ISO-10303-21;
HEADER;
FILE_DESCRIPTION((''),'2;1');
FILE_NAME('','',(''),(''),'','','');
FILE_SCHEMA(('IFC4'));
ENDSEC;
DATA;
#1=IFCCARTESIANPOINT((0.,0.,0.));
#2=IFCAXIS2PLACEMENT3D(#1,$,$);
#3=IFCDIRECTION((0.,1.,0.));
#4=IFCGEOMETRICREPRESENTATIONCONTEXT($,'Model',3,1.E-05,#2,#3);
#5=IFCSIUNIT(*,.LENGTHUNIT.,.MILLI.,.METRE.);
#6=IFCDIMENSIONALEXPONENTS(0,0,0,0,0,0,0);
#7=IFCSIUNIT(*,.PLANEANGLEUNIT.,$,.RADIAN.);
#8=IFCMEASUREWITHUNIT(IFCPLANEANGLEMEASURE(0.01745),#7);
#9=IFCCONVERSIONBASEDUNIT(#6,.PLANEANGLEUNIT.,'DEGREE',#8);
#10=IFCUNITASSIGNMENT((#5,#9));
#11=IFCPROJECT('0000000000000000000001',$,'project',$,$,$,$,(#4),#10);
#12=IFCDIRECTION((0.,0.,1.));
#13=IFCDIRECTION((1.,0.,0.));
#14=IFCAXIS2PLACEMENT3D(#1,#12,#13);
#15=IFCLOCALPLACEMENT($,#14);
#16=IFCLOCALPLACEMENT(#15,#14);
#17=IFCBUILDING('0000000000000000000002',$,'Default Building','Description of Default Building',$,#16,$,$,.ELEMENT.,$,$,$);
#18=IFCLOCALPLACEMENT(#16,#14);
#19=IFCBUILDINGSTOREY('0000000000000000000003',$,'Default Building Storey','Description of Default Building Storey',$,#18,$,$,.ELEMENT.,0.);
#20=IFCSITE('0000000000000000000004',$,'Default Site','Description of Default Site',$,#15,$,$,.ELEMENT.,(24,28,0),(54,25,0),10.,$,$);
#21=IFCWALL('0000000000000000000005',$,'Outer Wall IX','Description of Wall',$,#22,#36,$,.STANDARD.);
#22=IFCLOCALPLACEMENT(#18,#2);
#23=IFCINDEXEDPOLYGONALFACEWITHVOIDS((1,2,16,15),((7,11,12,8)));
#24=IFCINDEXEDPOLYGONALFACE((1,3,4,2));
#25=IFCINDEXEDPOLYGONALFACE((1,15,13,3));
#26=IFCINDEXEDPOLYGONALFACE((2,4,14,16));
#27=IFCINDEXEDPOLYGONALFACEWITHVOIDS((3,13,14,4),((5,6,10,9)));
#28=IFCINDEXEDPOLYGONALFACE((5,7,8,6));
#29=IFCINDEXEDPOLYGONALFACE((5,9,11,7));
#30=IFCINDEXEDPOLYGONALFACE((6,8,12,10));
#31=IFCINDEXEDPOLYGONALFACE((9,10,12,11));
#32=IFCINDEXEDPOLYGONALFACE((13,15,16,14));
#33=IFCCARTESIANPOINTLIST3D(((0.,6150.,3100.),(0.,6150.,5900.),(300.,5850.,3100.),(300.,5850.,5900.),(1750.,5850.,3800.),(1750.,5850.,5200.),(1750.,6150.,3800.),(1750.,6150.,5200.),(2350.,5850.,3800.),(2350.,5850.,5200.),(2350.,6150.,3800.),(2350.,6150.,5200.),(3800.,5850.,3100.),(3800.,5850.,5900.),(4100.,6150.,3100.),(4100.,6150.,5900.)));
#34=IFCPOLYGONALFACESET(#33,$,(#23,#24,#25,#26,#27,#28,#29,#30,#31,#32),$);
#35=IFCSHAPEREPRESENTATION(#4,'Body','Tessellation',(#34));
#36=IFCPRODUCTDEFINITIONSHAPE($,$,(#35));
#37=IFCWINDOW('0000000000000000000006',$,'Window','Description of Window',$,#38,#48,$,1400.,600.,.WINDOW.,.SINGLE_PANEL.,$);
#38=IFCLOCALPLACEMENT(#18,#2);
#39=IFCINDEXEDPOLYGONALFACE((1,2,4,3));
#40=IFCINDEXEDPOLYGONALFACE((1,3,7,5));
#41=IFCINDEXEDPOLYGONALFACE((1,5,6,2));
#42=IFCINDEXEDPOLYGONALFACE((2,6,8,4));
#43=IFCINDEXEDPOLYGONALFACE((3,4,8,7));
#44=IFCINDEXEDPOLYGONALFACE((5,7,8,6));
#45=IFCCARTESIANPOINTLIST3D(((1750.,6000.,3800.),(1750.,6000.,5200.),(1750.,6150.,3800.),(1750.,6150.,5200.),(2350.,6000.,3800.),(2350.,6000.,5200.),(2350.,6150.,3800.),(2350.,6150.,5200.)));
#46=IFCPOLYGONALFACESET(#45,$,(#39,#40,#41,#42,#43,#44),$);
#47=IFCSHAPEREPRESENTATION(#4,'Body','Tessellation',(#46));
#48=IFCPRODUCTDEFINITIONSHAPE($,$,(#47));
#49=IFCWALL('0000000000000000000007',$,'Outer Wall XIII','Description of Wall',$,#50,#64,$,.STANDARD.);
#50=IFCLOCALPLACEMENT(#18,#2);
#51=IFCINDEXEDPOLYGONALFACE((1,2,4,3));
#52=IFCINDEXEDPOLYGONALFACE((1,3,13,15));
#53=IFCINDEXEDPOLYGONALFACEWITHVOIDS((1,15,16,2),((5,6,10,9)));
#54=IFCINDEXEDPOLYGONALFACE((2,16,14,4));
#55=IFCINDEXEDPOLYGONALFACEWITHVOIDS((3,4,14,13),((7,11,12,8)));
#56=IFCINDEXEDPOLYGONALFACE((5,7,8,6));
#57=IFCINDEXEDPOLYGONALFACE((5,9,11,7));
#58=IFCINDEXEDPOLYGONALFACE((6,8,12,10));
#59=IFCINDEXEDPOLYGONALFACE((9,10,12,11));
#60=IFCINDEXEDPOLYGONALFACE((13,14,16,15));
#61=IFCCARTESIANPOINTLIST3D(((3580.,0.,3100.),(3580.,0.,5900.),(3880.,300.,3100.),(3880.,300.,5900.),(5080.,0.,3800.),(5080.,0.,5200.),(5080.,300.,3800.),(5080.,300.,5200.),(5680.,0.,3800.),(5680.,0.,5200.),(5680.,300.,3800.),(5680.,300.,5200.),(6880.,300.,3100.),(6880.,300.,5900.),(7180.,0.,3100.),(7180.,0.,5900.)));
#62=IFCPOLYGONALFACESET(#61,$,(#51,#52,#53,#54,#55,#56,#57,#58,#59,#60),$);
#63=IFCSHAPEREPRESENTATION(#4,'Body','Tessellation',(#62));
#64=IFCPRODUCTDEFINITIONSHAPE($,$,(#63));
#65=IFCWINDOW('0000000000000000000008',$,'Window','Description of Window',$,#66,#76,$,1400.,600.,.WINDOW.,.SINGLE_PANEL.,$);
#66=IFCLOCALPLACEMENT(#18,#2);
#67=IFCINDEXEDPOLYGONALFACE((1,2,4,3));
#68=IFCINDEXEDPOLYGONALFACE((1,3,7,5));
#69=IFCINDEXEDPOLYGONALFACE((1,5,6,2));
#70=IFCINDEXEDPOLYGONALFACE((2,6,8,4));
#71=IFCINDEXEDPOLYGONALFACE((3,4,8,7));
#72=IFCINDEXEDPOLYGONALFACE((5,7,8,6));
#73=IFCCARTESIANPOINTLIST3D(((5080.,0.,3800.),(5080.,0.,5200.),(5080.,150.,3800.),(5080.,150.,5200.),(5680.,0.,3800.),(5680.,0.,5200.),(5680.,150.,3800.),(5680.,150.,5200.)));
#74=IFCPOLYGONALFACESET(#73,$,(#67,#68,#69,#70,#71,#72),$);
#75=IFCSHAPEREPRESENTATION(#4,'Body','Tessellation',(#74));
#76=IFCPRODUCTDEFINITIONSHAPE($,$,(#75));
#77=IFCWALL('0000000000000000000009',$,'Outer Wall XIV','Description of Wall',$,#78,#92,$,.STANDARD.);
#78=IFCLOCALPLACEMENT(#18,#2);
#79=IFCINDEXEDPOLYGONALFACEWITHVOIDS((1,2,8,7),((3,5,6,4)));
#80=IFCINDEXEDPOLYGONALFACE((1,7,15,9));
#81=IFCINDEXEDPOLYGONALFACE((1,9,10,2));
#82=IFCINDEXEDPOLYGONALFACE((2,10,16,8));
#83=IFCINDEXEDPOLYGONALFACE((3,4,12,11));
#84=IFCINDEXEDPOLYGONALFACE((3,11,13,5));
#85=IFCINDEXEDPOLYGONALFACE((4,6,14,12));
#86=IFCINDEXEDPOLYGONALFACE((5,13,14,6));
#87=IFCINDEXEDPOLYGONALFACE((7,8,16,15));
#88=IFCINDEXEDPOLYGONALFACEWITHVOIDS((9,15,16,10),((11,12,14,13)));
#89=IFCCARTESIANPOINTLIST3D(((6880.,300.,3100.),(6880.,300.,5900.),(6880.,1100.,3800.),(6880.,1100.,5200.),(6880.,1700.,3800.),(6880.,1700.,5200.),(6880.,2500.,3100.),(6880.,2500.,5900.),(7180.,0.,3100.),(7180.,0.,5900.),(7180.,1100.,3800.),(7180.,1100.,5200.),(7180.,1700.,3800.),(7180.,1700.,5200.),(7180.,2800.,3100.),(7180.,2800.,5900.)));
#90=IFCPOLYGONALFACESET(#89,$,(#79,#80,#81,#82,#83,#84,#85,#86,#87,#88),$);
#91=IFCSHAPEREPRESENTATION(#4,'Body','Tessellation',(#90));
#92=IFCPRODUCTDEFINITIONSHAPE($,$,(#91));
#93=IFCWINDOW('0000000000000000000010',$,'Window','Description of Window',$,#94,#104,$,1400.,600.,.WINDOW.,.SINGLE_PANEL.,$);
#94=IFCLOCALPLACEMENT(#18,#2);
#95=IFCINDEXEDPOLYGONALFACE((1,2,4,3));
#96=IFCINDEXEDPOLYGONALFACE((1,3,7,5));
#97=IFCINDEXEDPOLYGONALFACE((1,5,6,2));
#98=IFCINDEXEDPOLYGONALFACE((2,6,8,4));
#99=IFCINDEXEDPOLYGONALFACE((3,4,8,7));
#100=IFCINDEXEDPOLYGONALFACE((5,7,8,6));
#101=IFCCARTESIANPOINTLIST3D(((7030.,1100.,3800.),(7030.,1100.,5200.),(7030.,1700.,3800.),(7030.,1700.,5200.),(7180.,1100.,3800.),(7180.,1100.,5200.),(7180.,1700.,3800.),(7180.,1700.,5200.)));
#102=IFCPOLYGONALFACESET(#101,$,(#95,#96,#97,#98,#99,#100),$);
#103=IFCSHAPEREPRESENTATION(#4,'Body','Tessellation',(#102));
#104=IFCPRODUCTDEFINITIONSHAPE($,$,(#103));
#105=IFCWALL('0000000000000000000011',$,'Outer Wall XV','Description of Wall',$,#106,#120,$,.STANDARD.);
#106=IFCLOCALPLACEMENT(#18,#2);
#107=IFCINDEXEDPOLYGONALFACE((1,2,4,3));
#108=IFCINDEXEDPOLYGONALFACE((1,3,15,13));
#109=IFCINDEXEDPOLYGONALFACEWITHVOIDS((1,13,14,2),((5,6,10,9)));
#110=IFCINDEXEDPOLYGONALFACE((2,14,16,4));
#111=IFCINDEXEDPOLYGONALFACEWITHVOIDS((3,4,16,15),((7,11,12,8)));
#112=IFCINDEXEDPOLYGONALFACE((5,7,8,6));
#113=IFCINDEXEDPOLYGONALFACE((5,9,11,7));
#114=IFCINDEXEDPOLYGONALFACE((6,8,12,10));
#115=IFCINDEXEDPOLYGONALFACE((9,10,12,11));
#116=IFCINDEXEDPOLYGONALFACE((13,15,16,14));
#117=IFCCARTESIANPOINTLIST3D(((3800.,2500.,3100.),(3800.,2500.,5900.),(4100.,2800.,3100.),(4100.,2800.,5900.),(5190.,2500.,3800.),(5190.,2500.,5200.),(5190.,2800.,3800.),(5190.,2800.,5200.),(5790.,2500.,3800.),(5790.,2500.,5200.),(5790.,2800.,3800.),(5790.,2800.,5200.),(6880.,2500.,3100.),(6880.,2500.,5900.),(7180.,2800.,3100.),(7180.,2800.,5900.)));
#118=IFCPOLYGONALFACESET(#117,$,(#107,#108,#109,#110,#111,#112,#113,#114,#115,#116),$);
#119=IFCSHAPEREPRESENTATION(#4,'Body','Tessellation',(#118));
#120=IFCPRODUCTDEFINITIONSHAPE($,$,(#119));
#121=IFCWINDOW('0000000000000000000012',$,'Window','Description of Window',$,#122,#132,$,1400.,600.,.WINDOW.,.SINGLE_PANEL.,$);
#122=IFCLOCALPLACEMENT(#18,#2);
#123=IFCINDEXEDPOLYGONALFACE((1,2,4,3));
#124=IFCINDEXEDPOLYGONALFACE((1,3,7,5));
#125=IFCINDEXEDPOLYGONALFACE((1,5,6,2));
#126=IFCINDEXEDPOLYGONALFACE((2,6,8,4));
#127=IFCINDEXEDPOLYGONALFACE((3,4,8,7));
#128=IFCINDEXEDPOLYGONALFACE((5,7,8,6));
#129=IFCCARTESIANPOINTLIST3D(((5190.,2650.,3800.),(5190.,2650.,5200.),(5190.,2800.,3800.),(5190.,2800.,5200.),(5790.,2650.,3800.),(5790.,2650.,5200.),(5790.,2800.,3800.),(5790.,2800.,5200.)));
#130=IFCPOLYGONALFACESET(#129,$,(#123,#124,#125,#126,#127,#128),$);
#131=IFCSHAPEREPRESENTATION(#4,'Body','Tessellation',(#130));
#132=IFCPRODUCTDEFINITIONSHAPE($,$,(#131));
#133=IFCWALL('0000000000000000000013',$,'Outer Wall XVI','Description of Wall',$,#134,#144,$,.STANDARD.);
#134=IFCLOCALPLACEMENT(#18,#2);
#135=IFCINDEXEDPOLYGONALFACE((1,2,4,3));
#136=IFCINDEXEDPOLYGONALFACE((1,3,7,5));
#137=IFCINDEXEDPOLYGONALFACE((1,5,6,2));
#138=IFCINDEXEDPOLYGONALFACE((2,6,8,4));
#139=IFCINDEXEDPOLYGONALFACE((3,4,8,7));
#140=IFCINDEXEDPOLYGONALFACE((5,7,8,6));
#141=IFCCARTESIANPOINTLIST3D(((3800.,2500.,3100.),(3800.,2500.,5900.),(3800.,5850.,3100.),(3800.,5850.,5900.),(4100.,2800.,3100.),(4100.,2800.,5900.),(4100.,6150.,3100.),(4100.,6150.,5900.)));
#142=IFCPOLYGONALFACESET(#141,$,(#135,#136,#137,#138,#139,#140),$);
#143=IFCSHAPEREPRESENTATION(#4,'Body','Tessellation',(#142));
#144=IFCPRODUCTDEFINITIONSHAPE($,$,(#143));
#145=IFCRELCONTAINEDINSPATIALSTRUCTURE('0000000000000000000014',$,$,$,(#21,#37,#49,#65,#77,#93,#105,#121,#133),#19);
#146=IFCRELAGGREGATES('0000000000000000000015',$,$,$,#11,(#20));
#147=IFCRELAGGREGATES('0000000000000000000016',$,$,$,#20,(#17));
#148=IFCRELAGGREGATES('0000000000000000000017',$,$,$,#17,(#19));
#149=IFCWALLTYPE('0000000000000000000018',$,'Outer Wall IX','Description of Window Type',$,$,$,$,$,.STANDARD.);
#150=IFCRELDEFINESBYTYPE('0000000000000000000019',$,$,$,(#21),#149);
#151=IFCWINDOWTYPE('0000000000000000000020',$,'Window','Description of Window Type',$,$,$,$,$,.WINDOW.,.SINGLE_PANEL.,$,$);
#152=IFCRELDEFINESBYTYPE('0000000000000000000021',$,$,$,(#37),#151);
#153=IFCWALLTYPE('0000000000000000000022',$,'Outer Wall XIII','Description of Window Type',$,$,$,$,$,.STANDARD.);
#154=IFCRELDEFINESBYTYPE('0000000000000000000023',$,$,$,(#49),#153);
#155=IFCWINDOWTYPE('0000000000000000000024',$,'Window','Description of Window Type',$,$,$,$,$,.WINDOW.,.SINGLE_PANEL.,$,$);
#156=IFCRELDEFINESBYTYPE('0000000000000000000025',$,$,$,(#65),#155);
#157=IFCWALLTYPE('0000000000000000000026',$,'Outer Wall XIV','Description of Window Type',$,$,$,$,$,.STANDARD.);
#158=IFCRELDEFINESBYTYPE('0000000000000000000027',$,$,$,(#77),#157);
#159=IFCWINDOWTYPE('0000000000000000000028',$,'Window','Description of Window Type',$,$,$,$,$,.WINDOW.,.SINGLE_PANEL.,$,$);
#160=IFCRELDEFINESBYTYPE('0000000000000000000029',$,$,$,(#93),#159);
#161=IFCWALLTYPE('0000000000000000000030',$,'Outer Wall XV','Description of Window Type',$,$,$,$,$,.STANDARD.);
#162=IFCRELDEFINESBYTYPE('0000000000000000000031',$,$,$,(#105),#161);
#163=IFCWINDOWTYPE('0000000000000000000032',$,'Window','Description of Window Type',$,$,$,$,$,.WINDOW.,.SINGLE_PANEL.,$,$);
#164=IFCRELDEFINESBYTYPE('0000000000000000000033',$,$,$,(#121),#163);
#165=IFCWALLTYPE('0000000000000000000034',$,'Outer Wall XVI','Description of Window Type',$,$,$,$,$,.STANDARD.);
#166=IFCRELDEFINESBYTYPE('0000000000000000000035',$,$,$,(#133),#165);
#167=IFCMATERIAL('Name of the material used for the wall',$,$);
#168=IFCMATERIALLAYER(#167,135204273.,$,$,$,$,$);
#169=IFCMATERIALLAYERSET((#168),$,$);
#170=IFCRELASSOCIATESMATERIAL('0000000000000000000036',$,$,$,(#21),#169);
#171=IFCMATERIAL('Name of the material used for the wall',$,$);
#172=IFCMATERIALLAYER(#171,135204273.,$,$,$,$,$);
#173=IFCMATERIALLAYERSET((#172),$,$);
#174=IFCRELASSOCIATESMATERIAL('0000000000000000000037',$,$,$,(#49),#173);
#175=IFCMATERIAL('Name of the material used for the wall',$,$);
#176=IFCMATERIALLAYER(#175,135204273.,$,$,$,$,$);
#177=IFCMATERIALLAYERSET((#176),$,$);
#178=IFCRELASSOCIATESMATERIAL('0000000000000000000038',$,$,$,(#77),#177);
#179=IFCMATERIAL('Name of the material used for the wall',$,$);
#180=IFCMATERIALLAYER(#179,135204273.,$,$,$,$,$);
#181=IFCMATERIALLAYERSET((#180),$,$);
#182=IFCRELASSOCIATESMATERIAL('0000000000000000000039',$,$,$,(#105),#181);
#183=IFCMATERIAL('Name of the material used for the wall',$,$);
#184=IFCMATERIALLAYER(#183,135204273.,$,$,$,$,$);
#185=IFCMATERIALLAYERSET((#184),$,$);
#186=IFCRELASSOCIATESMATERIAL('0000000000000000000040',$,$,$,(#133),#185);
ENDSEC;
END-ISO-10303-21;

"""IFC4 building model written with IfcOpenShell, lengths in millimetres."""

from ifc_helpers import new_model, entity, si_unit, converted_unit, direction, frame, origin, origin_with_axes, place, context, project, spatial, polyline, outline, extrude, material, layer, layer_set, layer_usage, type_object, element, fill, save


model = new_model("IFC4")

# Units and contexts
model_context = context("Model", 3, precision=1e-05, world=origin(), true_north=direction((0.0, 1.0, 0.0)))
ifc_project = project(units=[si_unit("LENGTHUNIT", "METRE", prefix="MILLI"), converted_unit("PLANEANGLEUNIT", "DEGREE", entity("IfcPlaneAngleMeasure", 0.01745), si_unit("PLANEANGLEUNIT", "RADIAN"), dimensions=[0, 0, 0, 0, 0, 0, 0])], contexts=[model_context])

# Site, building, storey
site_placement = place(None, origin_with_axes())
site = spatial("IfcSite", under=ifc_project, at=site_placement, Name="Default Site", Description="Description of Default Site", CompositionType="ELEMENT", RefLatitude=(24, 28, 0), RefLongitude=(54, 25, 0), RefElevation=10.0)
building_placement = place(site_placement, origin_with_axes())
building = spatial("IfcBuilding", under=site, at=building_placement, Name="Default Building", Description="Description of Default Building", CompositionType="ELEMENT")
storey_placement = place(building_placement, origin_with_axes())
storey = spatial("IfcBuildingStorey", under=building, at=storey_placement, Name="Default Building Storey", Description="Description of Default Building Storey", CompositionType="ELEMENT", Elevation=0.0)

# Walls, openings, windows
ifc_material_1 = material(Name="Name of the material used for the wall")
ifc_layer_1 = layer(ifc_material_1, 135204273.0)
ifc_layer_set_1 = layer_set([ifc_layer_1])
ifc_layer_usage_1 = layer_usage(ifc_layer_set_1, "AXIS2", "POSITIVE", -67602136.5)
wall_type_1 = type_object("IfcWallType", Name="Outer Wall IX", Description="Description of Window Type", PredefinedType="STANDARD")
wall_1_placement = place(storey_placement, frame((3950.0, 6000.0, 3100.0), z_axis=(0.0, 0.0, 1.0), x_axis=(-1.0, 0.0, 0.0)))
wall_1 = element("IfcWall", 1, at=wall_1_placement, inside=storey, type_object=wall_type_1, material=ifc_layer_usage_1, Name="Outer Wall IX", Description="Description of Wall", PredefinedType="STANDARD", context=model_context, shape_type="SweptSolid", body=[
    extrude(outline(polyline([(-150.0, -150.0), (150.0, 150.0), (3650.0, 150.0), (3950.0, -150.0), (-150.0, -150.0)])), origin_with_axes(), (0.0, 0.0, 1.0), 2800.0),
])
opening_1_placement = place(wall_1_placement, frame((1600.0, -150.0, 700.0), z_axis=(0.0, 0.0, 1.0), x_axis=(1.0, 0.0, 0.0)))
opening_1 = element("IfcOpeningElement", 2, at=opening_1_placement, cuts=wall_1, context=model_context, shape_type="SweptSolid", body=[
    extrude(outline(polyline([(0.0, 0.0), (0.0, 300.0), (600.0, 300.0), (600.0, 0.0), (0.0, 0.0)])), origin_with_axes(), (0.0, 0.0, 1.0), 1400.0),
])
window_type_1 = type_object("IfcWindowType", Name="Window", Description="Description of Window Type", PartitioningType="SINGLE_PANEL", PredefinedType="WINDOW")
window_1_placement = place(opening_1_placement, origin_with_axes())
window_1 = element("IfcWindow", 3, at=window_1_placement, inside=storey, type_object=window_type_1, Name="Window", Description="Description of Window", OverallHeight=1400.0, OverallWidth=600.0, PartitioningType="SINGLE_PANEL", PredefinedType="WINDOW", context=model_context, shape_type="SweptSolid", body=[
    extrude(outline(polyline([(0.0, 0.0), (0.0, 150.0), (600.0, 150.0), (600.0, 0.0), (0.0, 0.0)])), origin_with_axes(), (0.0, 0.0, 1.0), 1400.0),
])
fill(opening_1, window_1)
ifc_material_2 = material(Name="Name of the material used for the wall")
ifc_layer_2 = layer(ifc_material_2, 135204273.0)
ifc_layer_set_2 = layer_set([ifc_layer_2])
ifc_layer_usage_2 = layer_usage(ifc_layer_set_2, "AXIS2", "POSITIVE", -67602136.5)
wall_type_2 = type_object("IfcWallType", Name="Outer Wall XIII", Description="Description of Window Type", PredefinedType="STANDARD")
wall_2_placement = place(storey_placement, frame((3730.0, 150.0, 3100.0), z_axis=(0.0, 0.0, 1.0), x_axis=(1.0, 0.0, 0.0)))
wall_2 = element("IfcWall", 4, at=wall_2_placement, inside=storey, type_object=wall_type_2, material=ifc_layer_usage_2, Name="Outer Wall XIII", Description="Description of Wall", PredefinedType="STANDARD", context=model_context, shape_type="SweptSolid", body=[
    extrude(outline(polyline([(-150.0, -150.0), (150.0, 150.0), (3150.0, 150.0), (3450.0, -150.0), (-150.0, -150.0)])), origin_with_axes(), (0.0, 0.0, 1.0), 2800.0),
])
opening_2_placement = place(wall_2_placement, frame((1350.0, -150.0, 700.0), z_axis=(0.0, 0.0, 1.0), x_axis=(1.0, 0.0, 0.0)))
opening_2 = element("IfcOpeningElement", 5, at=opening_2_placement, cuts=wall_2, context=model_context, shape_type="SweptSolid", body=[
    extrude(outline(polyline([(0.0, 0.0), (0.0, 300.0), (600.0, 300.0), (600.0, 0.0), (0.0, 0.0)])), origin_with_axes(), (0.0, 0.0, 1.0), 1400.0),
])
window_type_2 = type_object("IfcWindowType", Name="Window", Description="Description of Window Type", PartitioningType="SINGLE_PANEL", PredefinedType="WINDOW")
window_2_placement = place(opening_2_placement, origin_with_axes())
window_2 = element("IfcWindow", 6, at=window_2_placement, inside=storey, type_object=window_type_2, Name="Window", Description="Description of Window", OverallHeight=1400.0, OverallWidth=600.0, PartitioningType="SINGLE_PANEL", PredefinedType="WINDOW", context=model_context, shape_type="SweptSolid", body=[
    extrude(outline(polyline([(0.0, 0.0), (0.0, 150.0), (600.0, 150.0), (600.0, 0.0), (0.0, 0.0)])), origin_with_axes(), (0.0, 0.0, 1.0), 1400.0),
])
fill(opening_2, window_2)
ifc_material_3 = material(Name="Name of the material used for the wall")
ifc_layer_3 = layer(ifc_material_3, 135204273.0)
ifc_layer_set_3 = layer_set([ifc_layer_3])
ifc_layer_usage_3 = layer_usage(ifc_layer_set_3, "AXIS2", "POSITIVE", -67602136.5)
wall_type_3 = type_object("IfcWallType", Name="Outer Wall XIV", Description="Description of Window Type", PredefinedType="STANDARD")
wall_3_placement = place(storey_placement, frame((7030.0, 150.0, 3100.0), z_axis=(0.0, 0.0, 1.0), x_axis=(0.0, 1.0, 0.0)))
wall_3 = element("IfcWall", 7, at=wall_3_placement, inside=storey, type_object=wall_type_3, material=ifc_layer_usage_3, Name="Outer Wall XIV", Description="Description of Wall", PredefinedType="STANDARD", context=model_context, shape_type="SweptSolid", body=[
    extrude(outline(polyline([(-150.0, -150.0), (150.0, 150.0), (2350.0, 150.0), (2650.0, -150.0), (-150.0, -150.0)])), origin_with_axes(), (0.0, 0.0, 1.0), 2800.0),
])
opening_3_placement = place(wall_3_placement, frame((950.0, -150.0, 700.0), z_axis=(0.0, 0.0, 1.0), x_axis=(1.0, 0.0, 0.0)))
opening_3 = element("IfcOpeningElement", 8, at=opening_3_placement, cuts=wall_3, context=model_context, shape_type="SweptSolid", body=[
    extrude(outline(polyline([(0.0, 0.0), (0.0, 300.0), (600.0, 300.0), (600.0, 0.0), (0.0, 0.0)])), origin_with_axes(), (0.0, 0.0, 1.0), 1400.0),
])
window_type_3 = type_object("IfcWindowType", Name="Window", Description="Description of Window Type", PartitioningType="SINGLE_PANEL", PredefinedType="WINDOW")
window_3_placement = place(opening_3_placement, origin_with_axes())
window_3 = element("IfcWindow", 9, at=window_3_placement, inside=storey, type_object=window_type_3, Name="Window", Description="Description of Window", OverallHeight=1400.0, OverallWidth=600.0, PartitioningType="SINGLE_PANEL", PredefinedType="WINDOW", context=model_context, shape_type="SweptSolid", body=[
    extrude(outline(polyline([(0.0, 0.0), (0.0, 150.0), (600.0, 150.0), (600.0, 0.0), (0.0, 0.0)])), origin_with_axes(), (0.0, 0.0, 1.0), 1400.0),
])
fill(opening_3, window_3)
ifc_material_4 = material(Name="Name of the material used for the wall")
ifc_layer_4 = layer(ifc_material_4, 135204273.0)
ifc_layer_set_4 = layer_set([ifc_layer_4])
ifc_layer_usage_4 = layer_usage(ifc_layer_set_4, "AXIS2", "POSITIVE", -67602136.5)
wall_type_4 = type_object("IfcWallType", Name="Outer Wall XV", Description="Description of Window Type", PredefinedType="STANDARD")
wall_4_placement = place(storey_placement, frame((7030.0, 2650.0, 3100.0), z_axis=(0.0, 0.0, 1.0), x_axis=(-1.0, 0.0, 0.0)))
wall_4 = element("IfcWall", 10, at=wall_4_placement, inside=storey, type_object=wall_type_4, material=ifc_layer_usage_4, Name="Outer Wall XV", Description="Description of Wall", PredefinedType="STANDARD", context=model_context, shape_type="SweptSolid", body=[
    extrude(outline(polyline([(-150.0, -150.0), (150.0, 150.0), (3230.0, 150.0), (2930.0, -150.0), (-150.0, -150.0)])), origin_with_axes(), (0.0, 0.0, 1.0), 2800.0),
])
opening_4_placement = place(wall_4_placement, frame((1240.0, -150.0, 700.0), z_axis=(0.0, 0.0, 1.0), x_axis=(1.0, 0.0, 0.0)))
opening_4 = element("IfcOpeningElement", 11, at=opening_4_placement, cuts=wall_4, context=model_context, shape_type="SweptSolid", body=[
    extrude(outline(polyline([(0.0, 0.0), (0.0, 300.0), (600.0, 300.0), (600.0, 0.0), (0.0, 0.0)])), origin_with_axes(), (0.0, 0.0, 1.0), 1400.0),
])
window_type_4 = type_object("IfcWindowType", Name="Window", Description="Description of Window Type", PartitioningType="SINGLE_PANEL", PredefinedType="WINDOW")
window_4_placement = place(opening_4_placement, origin_with_axes())
window_4 = element("IfcWindow", 12, at=window_4_placement, inside=storey, type_object=window_type_4, Name="Window", Description="Description of Window", OverallHeight=1400.0, OverallWidth=600.0, PartitioningType="SINGLE_PANEL", PredefinedType="WINDOW", context=model_context, shape_type="SweptSolid", body=[
    extrude(outline(polyline([(0.0, 0.0), (0.0, 150.0), (600.0, 150.0), (600.0, 0.0), (0.0, 0.0)])), origin_with_axes(), (0.0, 0.0, 1.0), 1400.0),
])
fill(opening_4, window_4)

# Wall
ifc_material_5 = material(Name="Name of the material used for the wall")
ifc_layer_5 = layer(ifc_material_5, 135204273.0)
ifc_layer_set_5 = layer_set([ifc_layer_5])
ifc_layer_usage_5 = layer_usage(ifc_layer_set_5, "AXIS2", "POSITIVE", -67602136.5)
wall_type_5 = type_object("IfcWallType", Name="Outer Wall XVI", Description="Description of Window Type", PredefinedType="STANDARD")
wall_5_placement = place(storey_placement, frame((3950.0, 2650.0, 3100.0), z_axis=(0.0, 0.0, 1.0), x_axis=(0.0, 1.0, 0.0)))
element("IfcWall", 13, at=wall_5_placement, inside=storey, type_object=wall_type_5, material=ifc_layer_usage_5, Name="Outer Wall XVI", Description="Description of Wall", PredefinedType="STANDARD", context=model_context, shape_type="SweptSolid", body=[
    extrude(outline(polyline([(150.0, -150.0), (-150.0, 150.0), (3200.0, 150.0), (3500.0, -150.0), (150.0, -150.0)])), origin_with_axes(), (0.0, 0.0, 1.0), 2800.0),
])

save(model, "model.ifc")
